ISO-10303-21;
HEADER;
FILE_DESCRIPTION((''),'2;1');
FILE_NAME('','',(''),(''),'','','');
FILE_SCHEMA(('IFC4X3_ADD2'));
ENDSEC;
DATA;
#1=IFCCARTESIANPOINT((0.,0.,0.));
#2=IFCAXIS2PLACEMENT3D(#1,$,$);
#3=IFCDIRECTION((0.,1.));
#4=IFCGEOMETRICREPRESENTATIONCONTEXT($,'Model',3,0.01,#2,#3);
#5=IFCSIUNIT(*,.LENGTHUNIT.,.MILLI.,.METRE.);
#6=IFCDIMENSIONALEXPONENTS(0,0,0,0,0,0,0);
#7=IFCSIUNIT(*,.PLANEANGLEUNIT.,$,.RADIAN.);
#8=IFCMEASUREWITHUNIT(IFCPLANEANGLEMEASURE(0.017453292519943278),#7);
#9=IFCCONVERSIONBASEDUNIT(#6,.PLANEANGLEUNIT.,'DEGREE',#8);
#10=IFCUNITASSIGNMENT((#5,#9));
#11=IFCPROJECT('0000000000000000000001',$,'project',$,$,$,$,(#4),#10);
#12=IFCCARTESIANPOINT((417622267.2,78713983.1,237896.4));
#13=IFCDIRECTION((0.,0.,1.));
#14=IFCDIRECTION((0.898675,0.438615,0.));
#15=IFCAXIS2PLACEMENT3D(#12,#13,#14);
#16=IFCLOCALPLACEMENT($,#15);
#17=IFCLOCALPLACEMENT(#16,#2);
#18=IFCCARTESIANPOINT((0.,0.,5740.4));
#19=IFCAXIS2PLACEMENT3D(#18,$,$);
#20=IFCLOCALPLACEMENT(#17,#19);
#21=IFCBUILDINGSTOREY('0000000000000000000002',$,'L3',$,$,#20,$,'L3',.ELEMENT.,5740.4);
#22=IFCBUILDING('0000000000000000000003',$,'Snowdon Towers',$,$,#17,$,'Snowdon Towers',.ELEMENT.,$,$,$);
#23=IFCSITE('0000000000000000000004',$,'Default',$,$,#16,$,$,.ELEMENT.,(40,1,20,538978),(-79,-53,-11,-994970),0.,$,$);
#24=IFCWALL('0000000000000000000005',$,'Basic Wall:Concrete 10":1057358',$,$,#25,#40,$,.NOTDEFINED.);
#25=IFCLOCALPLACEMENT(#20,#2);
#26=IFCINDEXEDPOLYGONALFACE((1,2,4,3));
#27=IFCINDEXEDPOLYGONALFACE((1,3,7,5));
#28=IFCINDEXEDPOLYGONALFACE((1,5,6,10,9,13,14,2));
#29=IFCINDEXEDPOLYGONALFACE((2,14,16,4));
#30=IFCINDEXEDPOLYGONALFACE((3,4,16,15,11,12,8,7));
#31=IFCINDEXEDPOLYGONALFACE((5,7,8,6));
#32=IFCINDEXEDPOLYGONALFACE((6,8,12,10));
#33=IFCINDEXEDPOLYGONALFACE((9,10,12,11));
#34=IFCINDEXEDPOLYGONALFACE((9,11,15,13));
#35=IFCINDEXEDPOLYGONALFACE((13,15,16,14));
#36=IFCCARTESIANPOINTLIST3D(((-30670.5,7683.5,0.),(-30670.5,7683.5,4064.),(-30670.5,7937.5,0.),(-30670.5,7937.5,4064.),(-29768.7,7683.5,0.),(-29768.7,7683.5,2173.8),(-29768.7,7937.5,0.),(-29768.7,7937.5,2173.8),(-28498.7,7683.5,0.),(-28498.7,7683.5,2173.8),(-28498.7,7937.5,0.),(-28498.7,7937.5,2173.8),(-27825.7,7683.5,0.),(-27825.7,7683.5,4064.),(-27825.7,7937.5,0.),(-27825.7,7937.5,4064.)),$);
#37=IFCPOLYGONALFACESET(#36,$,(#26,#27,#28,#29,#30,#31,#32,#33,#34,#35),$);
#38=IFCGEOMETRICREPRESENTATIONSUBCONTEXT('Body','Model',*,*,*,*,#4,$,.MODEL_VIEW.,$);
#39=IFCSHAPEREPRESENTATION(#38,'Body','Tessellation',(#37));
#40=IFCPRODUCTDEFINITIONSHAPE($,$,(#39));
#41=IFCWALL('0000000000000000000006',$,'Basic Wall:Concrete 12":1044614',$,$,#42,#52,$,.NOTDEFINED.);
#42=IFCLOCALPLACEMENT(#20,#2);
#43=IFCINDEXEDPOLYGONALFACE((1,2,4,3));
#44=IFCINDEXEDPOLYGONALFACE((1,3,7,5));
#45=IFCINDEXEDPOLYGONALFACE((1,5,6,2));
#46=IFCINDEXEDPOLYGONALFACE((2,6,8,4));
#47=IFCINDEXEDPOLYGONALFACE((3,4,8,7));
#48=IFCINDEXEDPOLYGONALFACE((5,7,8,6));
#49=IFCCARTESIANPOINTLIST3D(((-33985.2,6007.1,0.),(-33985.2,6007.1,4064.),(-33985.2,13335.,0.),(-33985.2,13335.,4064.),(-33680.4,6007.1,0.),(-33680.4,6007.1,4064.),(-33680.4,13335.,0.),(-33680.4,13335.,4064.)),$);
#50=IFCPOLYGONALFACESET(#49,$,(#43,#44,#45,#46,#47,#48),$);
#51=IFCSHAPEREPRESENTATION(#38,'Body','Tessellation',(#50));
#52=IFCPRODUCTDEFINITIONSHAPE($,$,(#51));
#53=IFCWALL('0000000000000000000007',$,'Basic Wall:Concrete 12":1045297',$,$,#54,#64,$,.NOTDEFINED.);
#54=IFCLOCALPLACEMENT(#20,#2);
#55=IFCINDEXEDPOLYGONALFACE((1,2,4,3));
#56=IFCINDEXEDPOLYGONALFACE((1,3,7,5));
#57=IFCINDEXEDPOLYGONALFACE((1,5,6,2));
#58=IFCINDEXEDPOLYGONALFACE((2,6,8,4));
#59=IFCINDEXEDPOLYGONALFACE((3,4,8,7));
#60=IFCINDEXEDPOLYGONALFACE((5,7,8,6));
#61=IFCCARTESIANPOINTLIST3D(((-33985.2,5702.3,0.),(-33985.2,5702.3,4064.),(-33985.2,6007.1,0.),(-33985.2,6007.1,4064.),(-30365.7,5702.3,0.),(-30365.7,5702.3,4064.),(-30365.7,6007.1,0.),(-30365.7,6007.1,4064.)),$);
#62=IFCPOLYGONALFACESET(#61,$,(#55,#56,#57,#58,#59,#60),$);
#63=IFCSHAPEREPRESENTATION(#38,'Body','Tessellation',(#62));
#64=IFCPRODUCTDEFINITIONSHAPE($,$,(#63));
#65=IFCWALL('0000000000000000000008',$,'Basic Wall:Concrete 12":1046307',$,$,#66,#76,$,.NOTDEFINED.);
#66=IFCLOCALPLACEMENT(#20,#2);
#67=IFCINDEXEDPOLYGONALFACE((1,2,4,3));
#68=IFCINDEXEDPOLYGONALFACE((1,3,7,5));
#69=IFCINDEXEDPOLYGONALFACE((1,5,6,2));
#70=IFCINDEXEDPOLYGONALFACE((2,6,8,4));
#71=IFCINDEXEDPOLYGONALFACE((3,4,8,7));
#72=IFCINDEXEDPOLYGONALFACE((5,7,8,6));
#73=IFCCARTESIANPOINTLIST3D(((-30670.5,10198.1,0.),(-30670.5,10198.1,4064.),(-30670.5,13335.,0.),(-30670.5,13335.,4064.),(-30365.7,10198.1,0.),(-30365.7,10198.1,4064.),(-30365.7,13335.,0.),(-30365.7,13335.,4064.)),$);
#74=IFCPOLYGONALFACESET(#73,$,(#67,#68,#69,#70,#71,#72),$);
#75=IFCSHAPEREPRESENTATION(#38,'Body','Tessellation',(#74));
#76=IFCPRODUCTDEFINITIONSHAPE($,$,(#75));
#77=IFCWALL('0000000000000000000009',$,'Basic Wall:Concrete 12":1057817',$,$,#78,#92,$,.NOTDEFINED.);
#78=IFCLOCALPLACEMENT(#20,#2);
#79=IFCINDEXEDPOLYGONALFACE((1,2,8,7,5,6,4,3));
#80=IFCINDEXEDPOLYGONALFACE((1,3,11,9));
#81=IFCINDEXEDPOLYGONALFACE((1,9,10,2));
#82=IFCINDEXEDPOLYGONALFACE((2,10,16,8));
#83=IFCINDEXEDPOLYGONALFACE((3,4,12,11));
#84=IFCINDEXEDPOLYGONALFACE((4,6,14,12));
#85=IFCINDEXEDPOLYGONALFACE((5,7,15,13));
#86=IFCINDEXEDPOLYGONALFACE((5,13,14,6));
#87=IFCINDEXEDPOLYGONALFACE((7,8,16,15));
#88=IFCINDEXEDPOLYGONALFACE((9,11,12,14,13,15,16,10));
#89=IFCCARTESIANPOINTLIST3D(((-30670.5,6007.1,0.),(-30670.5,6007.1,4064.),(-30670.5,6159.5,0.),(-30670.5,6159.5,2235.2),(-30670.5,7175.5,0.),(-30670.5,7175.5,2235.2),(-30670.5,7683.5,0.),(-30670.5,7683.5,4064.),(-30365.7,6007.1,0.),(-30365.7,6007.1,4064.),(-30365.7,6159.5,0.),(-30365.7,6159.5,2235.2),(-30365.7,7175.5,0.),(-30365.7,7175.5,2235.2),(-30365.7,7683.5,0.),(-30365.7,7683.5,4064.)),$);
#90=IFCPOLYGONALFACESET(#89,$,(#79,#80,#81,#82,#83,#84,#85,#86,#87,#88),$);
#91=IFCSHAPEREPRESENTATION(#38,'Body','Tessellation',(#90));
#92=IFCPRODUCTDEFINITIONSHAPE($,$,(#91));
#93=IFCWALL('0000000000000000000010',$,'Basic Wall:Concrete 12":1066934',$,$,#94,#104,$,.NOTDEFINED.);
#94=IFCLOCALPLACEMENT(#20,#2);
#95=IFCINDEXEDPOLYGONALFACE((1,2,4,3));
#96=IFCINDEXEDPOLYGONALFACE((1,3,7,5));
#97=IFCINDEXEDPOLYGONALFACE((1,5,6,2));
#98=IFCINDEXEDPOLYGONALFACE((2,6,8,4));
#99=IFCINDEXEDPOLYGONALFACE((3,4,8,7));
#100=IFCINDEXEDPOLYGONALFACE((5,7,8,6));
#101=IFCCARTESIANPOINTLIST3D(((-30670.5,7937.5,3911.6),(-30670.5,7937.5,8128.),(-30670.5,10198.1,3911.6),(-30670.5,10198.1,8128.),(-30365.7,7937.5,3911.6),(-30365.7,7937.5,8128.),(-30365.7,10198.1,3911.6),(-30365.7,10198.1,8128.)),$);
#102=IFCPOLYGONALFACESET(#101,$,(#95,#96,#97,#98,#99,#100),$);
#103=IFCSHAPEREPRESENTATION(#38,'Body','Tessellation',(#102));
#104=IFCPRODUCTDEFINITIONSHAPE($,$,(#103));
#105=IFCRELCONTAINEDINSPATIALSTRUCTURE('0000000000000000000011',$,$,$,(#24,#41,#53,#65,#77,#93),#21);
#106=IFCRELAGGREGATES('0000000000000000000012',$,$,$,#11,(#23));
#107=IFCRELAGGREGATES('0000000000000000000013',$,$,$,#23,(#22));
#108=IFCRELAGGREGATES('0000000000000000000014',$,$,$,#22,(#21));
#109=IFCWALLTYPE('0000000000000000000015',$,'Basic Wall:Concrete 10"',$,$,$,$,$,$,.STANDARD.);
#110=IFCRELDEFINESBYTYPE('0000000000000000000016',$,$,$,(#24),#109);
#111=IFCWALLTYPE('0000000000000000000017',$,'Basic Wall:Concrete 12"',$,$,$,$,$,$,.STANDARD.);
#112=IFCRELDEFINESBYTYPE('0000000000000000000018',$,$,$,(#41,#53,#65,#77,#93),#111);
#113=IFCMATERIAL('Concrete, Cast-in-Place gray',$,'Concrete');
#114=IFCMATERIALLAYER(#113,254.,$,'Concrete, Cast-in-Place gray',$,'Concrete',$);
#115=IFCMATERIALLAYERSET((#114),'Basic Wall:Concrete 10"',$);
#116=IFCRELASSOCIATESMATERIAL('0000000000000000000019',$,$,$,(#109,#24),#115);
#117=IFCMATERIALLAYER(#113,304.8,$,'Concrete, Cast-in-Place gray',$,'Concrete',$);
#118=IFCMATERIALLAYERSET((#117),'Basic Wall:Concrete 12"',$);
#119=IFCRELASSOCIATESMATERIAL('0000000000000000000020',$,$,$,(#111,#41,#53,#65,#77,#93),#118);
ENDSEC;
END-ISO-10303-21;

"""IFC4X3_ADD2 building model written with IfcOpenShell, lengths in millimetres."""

from ifc_helpers import new_model, entity, si_unit, converted_unit, direction, frame, frame_2d, origin, place, context, subcontext, project, spatial, rectangle, extrude, material, layer, layer_set, type_object, element, save


model = new_model("IFC4X3_ADD2")

# Units and contexts
model_context = context("Model", 3, precision=0.01, world=origin(), true_north=direction((0.0, 1.0)))
body_context = subcontext(model_context, "Body", "Model", "MODEL_VIEW")
ifc_project = project(units=[si_unit("LENGTHUNIT", "METRE", prefix="MILLI"), converted_unit("PLANEANGLEUNIT", "DEGREE", entity("IfcPlaneAngleMeasure", 0.017453292519943278), si_unit("PLANEANGLEUNIT", "RADIAN"), dimensions=[0, 0, 0, 0, 0, 0, 0])], contexts=[model_context])

# Site, building, storey
site_placement = place(None, frame((417622267.2, 78713983.1, 237896.4), z_axis=(0.0, 0.0, 1.0), x_axis=(0.898675, 0.438615, 0.0)))
site = spatial("IfcSite", under=ifc_project, at=site_placement, Name="Default", CompositionType="ELEMENT", RefLatitude=(40, 1, 20, 538978), RefLongitude=(-79, -53, -11, -994970), RefElevation=0.0)
building_placement = place(site_placement, origin())
building = spatial("IfcBuilding", under=site, at=building_placement, Name="Snowdon Towers", LongName="Snowdon Towers", CompositionType="ELEMENT")
storey_placement = place(building_placement, frame((0.0, 0.0, 5740.4)))
storey = spatial("IfcBuildingStorey", under=building, at=storey_placement, Name="L3", LongName="L3", CompositionType="ELEMENT", Elevation=5740.4)

# Shared definitions
ifc_material_1 = material(Name="Concrete, Cast-in-Place gray", Category="Concrete")
ifc_layer_1 = layer(ifc_material_1, 254.0, Name="Concrete, Cast-in-Place gray", Category="Concrete")
ifc_layer_set_1 = layer_set([ifc_layer_1], Name="Basic Wall:Concrete 10\"")
wall_type_1 = type_object("IfcWallType", Name="Basic Wall:Concrete 10\"", PredefinedType="STANDARD", material=ifc_layer_set_1)

# Wall, opening
wall_1_placement = place(storey_placement, frame((-27825.7, 7810.5, 0.0), z_axis=(0.0, 0.0, 1.0), x_axis=(-1.0, 0.0, 0.0)))
wall_1 = element("IfcWall", 1, at=wall_1_placement, inside=storey, type_object=wall_type_1, material=ifc_layer_set_1, Name="Basic Wall:Concrete 10\":1057358", PredefinedType="NOTDEFINED", context=body_context, shape_type="SweptSolid", body=[
    extrude(rectangle(XDim=2844.8, YDim=254.0, at=frame_2d((1422.4, 0.0), x_axis=(-1.0, 0.0))), origin(), (0.0, 0.0, 1.0), 4064.0),
])
opening_1_placement = place(wall_1_placement, origin())
element("IfcOpeningElement", 2, at=opening_1_placement, cuts=wall_1, PredefinedType="OPENING", context=body_context, shape_type="SweptSolid", body=[
    extrude(rectangle(XDim=2173.8, YDim=1270.0, at=frame_2d((0.0, 0.0), x_axis=(0.0, -1.0))), frame((1308.0, 127.0, 1086.9), z_axis=(0.0, 1.0, 0.0), x_axis=(1.0, 0.0, 0.0)), (0.0, 0.0, -1.0), 254.0),
])

# Walls
ifc_layer_2 = layer(ifc_material_1, 304.8, Name="Concrete, Cast-in-Place gray", Category="Concrete")
ifc_layer_set_2 = layer_set([ifc_layer_2], Name="Basic Wall:Concrete 12\"")
wall_type_2 = type_object("IfcWallType", Name="Basic Wall:Concrete 12\"", PredefinedType="STANDARD", material=ifc_layer_set_2)
wall_2_placement = place(storey_placement, frame((-33832.8, 13335.0, 0.0), z_axis=(0.0, 0.0, 1.0), x_axis=(0.0, -1.0, 0.0)))
element("IfcWall", 3, at=wall_2_placement, inside=storey, type_object=wall_type_2, material=ifc_layer_set_2, Name="Basic Wall:Concrete 12\":1044614", PredefinedType="NOTDEFINED", context=body_context, shape_type="SweptSolid", body=[
    extrude(rectangle(XDim=7327.9, YDim=304.8, at=frame_2d((3664.0, 0.0), x_axis=(-1.0, 0.0))), origin(), (0.0, 0.0, 1.0), 4064.0),
])
wall_3_placement = place(storey_placement, frame((-30365.7, 5854.7, 0.0), z_axis=(0.0, 0.0, 1.0), x_axis=(-1.0, 0.0, 0.0)))
element("IfcWall", 4, at=wall_3_placement, inside=storey, type_object=wall_type_2, material=ifc_layer_set_2, Name="Basic Wall:Concrete 12\":1045297", PredefinedType="NOTDEFINED", context=body_context, shape_type="SweptSolid", body=[
    extrude(rectangle(XDim=3619.5, YDim=304.8, at=frame_2d((1809.8, 0.0), x_axis=(-1.0, 0.0))), origin(), (0.0, 0.0, 1.0), 4064.0),
])
wall_4_placement = place(storey_placement, frame((-30518.1, 10198.1, 0.0), z_axis=(0.0, 0.0, 1.0), x_axis=(0.0, 1.0, 0.0)))
element("IfcWall", 5, at=wall_4_placement, inside=storey, type_object=wall_type_2, material=ifc_layer_set_2, Name="Basic Wall:Concrete 12\":1046307", PredefinedType="NOTDEFINED", context=body_context, shape_type="SweptSolid", body=[
    extrude(rectangle(XDim=3136.9, YDim=304.8, at=frame_2d((1568.5, 0.0), x_axis=(-1.0, 0.0))), origin(), (0.0, 0.0, 1.0), 4064.0),
])

# Wall, opening
wall_5_placement = place(storey_placement, frame((-30518.1, 7683.5, 0.0), z_axis=(0.0, 0.0, 1.0), x_axis=(0.0, -1.0, 0.0)))
wall_5 = element("IfcWall", 6, at=wall_5_placement, inside=storey, type_object=wall_type_2, material=ifc_layer_set_2, Name="Basic Wall:Concrete 12\":1057817", PredefinedType="NOTDEFINED", context=body_context, shape_type="SweptSolid", body=[
    extrude(rectangle(XDim=1676.4, YDim=304.8, at=frame_2d((838.2, 0.0), x_axis=(-1.0, 0.0))), origin(), (0.0, 0.0, 1.0), 4064.0),
])
opening_2_placement = place(wall_5_placement, origin())
element("IfcOpeningElement", 7, at=opening_2_placement, cuts=wall_5, PredefinedType="OPENING", context=body_context, shape_type="SweptSolid", body=[
    extrude(rectangle(XDim=2235.2, YDim=1016.0, at=frame_2d((0.0, 0.0), x_axis=(0.0, 1.0))), frame((1016.0, 152.4, 1117.6), z_axis=(0.0, -1.0, 0.0), x_axis=(1.0, 0.0, 0.0)), (0.0, 0.0, 1.0), 304.8),
])

# Wall
wall_6_placement = place(storey_placement, frame((-30518.1, 7937.5, 3911.6), z_axis=(0.0, 0.0, 1.0), x_axis=(0.0, 1.0, 0.0)))
element("IfcWall", 8, at=wall_6_placement, inside=storey, type_object=wall_type_2, material=ifc_layer_set_2, Name="Basic Wall:Concrete 12\":1066934", PredefinedType="NOTDEFINED", context=body_context, shape_type="SweptSolid", body=[
    extrude(rectangle(XDim=2260.6, YDim=304.8, at=frame_2d((1130.3, 0.0), x_axis=(-1.0, 0.0))), origin(), (0.0, 0.0, 1.0), 4216.4),
])

save(model, "model.ifc")
